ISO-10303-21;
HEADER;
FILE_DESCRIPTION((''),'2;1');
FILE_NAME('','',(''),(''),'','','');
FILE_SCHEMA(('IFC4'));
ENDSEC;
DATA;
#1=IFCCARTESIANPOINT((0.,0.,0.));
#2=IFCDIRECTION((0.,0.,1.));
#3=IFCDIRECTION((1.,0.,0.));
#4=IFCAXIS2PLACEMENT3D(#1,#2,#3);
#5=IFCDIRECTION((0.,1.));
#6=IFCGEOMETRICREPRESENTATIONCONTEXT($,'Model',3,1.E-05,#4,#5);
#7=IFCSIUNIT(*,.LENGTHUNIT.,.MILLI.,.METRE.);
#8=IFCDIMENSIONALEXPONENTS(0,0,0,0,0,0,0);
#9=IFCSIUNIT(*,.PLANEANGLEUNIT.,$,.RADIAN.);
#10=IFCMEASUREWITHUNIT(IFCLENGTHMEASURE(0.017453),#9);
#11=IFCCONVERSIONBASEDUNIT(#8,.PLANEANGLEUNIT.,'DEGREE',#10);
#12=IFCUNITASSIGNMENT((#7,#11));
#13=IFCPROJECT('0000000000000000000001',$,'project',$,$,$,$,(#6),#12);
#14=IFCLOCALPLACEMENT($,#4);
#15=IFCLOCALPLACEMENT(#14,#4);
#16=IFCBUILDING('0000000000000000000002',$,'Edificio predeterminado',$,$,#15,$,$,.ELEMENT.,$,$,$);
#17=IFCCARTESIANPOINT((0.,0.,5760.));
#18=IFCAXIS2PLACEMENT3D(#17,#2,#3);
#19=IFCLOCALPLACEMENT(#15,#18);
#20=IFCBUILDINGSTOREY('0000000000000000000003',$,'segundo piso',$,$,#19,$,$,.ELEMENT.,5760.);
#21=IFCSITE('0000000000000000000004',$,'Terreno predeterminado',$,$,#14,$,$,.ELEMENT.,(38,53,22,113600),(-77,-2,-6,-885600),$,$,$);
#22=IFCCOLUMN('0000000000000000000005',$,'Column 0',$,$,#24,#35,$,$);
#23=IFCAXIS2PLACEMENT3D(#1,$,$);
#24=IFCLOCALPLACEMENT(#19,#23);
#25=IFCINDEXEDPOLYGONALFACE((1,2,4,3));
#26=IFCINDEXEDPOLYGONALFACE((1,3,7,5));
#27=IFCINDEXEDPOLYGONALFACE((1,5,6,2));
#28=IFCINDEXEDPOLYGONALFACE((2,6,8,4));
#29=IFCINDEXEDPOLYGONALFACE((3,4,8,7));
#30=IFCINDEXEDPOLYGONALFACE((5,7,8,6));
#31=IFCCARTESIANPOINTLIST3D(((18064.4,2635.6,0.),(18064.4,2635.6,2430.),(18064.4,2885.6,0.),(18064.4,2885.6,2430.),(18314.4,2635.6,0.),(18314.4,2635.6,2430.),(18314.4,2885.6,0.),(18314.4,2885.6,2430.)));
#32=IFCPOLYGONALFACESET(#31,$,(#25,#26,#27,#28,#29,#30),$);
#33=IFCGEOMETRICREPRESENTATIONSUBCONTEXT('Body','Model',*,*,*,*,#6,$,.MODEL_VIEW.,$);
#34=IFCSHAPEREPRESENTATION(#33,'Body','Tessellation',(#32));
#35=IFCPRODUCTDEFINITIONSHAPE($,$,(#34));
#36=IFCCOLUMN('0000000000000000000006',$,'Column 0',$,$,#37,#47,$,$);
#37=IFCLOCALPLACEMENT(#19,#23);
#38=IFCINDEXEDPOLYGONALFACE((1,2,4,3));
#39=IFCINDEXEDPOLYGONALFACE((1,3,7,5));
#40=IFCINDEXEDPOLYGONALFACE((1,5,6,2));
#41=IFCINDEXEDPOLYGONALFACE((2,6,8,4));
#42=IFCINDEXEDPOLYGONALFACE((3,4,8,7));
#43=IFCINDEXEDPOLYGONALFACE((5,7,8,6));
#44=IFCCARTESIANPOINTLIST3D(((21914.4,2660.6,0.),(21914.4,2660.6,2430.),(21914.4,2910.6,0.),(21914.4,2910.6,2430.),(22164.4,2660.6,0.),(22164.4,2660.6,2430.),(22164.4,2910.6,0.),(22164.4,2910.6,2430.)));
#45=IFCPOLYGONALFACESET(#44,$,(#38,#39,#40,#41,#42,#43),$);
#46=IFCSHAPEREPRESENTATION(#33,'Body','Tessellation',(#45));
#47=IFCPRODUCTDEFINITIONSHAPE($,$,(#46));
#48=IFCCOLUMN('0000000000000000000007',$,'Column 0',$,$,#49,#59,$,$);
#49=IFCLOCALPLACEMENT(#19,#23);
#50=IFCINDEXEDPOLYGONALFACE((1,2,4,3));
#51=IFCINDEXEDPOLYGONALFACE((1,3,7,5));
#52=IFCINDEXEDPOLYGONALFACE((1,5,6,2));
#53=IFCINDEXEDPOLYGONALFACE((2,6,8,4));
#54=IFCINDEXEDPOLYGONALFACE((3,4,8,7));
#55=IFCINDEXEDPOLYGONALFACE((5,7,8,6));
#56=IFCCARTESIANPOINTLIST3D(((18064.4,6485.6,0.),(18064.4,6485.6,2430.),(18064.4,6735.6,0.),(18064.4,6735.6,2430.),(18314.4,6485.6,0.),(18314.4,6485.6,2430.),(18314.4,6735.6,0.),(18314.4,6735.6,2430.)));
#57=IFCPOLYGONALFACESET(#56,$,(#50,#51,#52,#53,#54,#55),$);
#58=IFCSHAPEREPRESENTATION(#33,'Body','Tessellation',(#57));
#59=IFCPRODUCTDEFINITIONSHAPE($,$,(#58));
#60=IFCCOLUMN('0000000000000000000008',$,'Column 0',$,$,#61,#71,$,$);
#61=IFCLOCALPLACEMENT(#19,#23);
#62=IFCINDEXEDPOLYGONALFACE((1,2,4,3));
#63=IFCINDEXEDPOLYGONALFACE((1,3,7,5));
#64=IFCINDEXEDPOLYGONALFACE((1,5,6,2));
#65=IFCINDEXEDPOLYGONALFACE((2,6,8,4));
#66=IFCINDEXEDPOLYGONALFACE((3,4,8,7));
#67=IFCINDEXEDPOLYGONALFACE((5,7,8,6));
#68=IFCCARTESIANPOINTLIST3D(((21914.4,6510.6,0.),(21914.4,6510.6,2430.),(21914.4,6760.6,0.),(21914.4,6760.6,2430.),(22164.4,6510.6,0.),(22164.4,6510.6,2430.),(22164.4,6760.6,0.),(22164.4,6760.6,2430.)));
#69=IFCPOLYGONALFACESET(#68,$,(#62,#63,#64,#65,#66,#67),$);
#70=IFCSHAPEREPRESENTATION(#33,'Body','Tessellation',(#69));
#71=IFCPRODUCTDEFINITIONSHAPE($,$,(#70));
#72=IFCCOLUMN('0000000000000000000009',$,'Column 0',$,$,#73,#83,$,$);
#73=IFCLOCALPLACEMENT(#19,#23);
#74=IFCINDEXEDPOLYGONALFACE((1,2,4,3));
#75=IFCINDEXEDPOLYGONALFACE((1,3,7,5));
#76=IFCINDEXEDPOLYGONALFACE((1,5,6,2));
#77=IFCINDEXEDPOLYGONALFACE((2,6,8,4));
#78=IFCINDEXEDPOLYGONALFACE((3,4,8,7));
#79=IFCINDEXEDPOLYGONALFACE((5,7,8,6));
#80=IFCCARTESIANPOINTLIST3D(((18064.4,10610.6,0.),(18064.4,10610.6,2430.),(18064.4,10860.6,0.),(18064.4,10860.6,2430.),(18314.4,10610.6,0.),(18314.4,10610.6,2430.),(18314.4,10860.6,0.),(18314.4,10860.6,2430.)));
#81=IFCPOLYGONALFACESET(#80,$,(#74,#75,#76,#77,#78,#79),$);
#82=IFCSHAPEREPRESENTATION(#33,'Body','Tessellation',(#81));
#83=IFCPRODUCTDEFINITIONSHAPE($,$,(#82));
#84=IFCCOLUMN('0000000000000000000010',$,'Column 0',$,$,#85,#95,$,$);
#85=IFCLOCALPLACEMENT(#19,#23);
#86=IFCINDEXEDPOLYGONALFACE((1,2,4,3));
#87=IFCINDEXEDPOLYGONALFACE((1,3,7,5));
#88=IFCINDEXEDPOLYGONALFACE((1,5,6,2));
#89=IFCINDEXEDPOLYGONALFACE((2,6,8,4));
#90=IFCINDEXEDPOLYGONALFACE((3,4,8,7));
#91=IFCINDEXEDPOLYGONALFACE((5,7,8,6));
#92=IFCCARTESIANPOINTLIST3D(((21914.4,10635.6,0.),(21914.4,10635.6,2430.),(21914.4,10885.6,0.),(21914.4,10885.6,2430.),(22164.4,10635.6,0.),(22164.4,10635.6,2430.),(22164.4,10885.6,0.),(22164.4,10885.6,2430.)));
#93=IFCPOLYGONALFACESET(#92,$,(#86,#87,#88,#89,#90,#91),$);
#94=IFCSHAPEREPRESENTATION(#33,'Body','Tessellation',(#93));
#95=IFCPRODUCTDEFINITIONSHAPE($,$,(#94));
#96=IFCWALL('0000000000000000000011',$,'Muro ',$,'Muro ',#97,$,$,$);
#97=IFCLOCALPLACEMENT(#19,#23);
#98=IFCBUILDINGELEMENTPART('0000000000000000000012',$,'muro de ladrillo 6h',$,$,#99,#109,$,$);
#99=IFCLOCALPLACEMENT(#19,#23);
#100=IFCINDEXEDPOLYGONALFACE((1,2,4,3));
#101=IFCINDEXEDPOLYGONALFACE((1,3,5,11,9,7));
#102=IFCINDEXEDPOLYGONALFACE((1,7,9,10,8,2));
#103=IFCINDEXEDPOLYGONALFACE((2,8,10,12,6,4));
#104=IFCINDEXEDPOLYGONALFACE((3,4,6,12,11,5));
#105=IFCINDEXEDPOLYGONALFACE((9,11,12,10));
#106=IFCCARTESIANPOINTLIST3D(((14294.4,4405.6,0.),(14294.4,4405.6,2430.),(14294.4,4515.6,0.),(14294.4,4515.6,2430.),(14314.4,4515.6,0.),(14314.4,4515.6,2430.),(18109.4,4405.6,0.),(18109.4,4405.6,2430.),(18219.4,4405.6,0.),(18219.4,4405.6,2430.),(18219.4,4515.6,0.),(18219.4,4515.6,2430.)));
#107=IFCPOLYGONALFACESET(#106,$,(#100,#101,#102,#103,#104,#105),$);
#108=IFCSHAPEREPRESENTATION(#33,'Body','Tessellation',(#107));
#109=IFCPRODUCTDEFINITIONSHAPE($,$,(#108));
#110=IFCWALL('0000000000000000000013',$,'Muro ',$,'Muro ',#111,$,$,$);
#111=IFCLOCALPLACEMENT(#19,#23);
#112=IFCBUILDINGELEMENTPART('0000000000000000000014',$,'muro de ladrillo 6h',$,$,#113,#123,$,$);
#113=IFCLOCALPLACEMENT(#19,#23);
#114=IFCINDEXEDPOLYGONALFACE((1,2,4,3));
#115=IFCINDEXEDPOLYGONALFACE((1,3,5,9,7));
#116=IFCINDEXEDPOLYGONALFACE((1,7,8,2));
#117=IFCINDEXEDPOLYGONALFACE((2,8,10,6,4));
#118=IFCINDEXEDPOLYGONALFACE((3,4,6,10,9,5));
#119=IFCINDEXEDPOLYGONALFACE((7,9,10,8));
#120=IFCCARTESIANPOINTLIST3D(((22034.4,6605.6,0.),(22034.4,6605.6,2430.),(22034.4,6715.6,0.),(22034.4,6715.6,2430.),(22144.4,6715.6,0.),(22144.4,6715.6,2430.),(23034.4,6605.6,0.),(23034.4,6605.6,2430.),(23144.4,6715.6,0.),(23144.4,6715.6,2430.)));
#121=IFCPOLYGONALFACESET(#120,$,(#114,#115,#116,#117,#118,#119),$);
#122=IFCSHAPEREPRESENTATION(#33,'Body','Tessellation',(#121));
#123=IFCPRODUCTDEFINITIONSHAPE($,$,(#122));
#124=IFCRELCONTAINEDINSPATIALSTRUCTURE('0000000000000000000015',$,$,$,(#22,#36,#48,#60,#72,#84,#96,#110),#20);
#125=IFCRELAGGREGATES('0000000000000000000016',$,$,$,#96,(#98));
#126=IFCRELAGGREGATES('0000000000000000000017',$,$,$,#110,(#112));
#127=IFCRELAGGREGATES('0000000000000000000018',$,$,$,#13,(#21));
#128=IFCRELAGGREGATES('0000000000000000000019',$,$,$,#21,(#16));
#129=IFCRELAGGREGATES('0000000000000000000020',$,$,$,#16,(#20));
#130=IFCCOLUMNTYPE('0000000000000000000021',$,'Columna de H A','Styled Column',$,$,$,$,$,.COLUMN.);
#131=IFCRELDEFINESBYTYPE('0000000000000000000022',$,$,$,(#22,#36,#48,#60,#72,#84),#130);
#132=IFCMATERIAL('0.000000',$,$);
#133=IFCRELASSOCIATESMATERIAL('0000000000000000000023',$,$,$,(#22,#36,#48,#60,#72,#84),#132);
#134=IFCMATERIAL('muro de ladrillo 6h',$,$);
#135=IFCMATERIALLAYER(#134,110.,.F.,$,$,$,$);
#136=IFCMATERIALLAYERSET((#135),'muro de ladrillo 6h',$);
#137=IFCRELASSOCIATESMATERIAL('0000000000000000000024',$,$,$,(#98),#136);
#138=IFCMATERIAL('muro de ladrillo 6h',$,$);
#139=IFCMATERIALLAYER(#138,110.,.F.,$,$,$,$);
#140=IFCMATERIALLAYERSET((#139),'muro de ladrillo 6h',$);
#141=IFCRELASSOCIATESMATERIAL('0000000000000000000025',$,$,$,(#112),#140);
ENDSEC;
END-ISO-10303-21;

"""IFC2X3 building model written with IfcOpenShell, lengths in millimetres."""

from ifc_helpers import new_model, entity, si_unit, converted_unit, direction, frame, origin_with_axes, place, context, subcontext, project, spatial, polyline, outline, extrude, material, layer, layer_set, layer_usage, type_object, element, aggregate, save


model = new_model("IFC2X3")

# Units and contexts
model_context = context("Model", 3, precision=1e-05, world=origin_with_axes(), true_north=direction((0.0, 1.0)))
body_context = subcontext(model_context, "Body", "Model", "MODEL_VIEW")
ifc_project = project(units=[si_unit("LENGTHUNIT", "METRE", prefix="MILLI"), converted_unit("PLANEANGLEUNIT", "DEGREE", entity("IfcLengthMeasure", 0.017453), si_unit("PLANEANGLEUNIT", "RADIAN"), dimensions=[0, 0, 0, 0, 0, 0, 0])], contexts=[model_context])

# Site, building, storey
site_placement = place(None, origin_with_axes())
site = spatial("IfcSite", under=ifc_project, at=site_placement, Name="Terreno predeterminado", CompositionType="ELEMENT", RefLatitude=(38, 53, 22, 113600), RefLongitude=(-77, -2, -6, -885600))
building_placement = place(site_placement, origin_with_axes())
building = spatial("IfcBuilding", under=site, at=building_placement, Name="Edificio predeterminado", CompositionType="ELEMENT")
storey_placement = place(building_placement, frame((0.0, 0.0, 5760.0), z_axis=(0.0, 0.0, 1.0), x_axis=(1.0, 0.0, 0.0)))
storey = spatial("IfcBuildingStorey", under=building, at=storey_placement, Name="segundo piso", CompositionType="ELEMENT", Elevation=5760.0)

# Columns
ifc_material_1 = material(Name="0.000000")
column_type = type_object("IfcColumnType", Name="Columna de H A", Description="Styled Column", PredefinedType="COLUMN")
for number, where, z_axis, x_axis, name in (
    (1, (18189.4, 2760.6, 0.0), (0.0, 0.0, 1.0), (1.0, 0.0, 0.0), "Column 0"),
    (2, (22039.4, 2785.6, 0.0), (0.0, 0.0, 1.0), (1.0, 0.0, 0.0), "Column 0"),
    (3, (18189.4, 6610.6, 0.0), (0.0, 0.0, 1.0), (1.0, 0.0, 0.0), "Column 0"),
    (4, (22039.4, 6635.6, 0.0), (0.0, 0.0, 1.0), (1.0, 0.0, 0.0), "Column 0"),
    (5, (18189.4, 10735.6, 0.0), (0.0, 0.0, 1.0), (1.0, 0.0, 0.0), "Column 0"),
    (6, (22039.4, 10760.6, 0.0), (0.0, 0.0, 1.0), (1.0, 0.0, 0.0), "Column 0"),
):
    element("IfcColumn", number, at=place(storey_placement, frame(where, z_axis=z_axis, x_axis=x_axis)), inside=storey, type_object=column_type, material=ifc_material_1, Name=name, context=body_context, shape_type="SweptSolid", body=[
        extrude(outline(polyline([(-125.0, -125.0), (125.0, -125.0), (125.0, 125.0), (-125.0, 125.0), (-125.0, -125.0)])), origin_with_axes(), (0.0, 0.0, 1.0), 2430.0),
    ])

# Walls, building element parts
wall_1_placement = place(storey_placement, frame((18164.4, 4460.6, 0.0), z_axis=(0.0, 0.0, 1.0), x_axis=(-1.0, 0.0, 0.0)))
wall_1 = element("IfcWall", 7, at=wall_1_placement, inside=storey, Name="Muro ", ObjectType="Muro ")
ifc_material_2 = material(Name="muro de ladrillo 6h")
ifc_layer_1 = layer(ifc_material_2, 110.0, ventilated=False)
ifc_layer_set_1 = layer_set([ifc_layer_1], Name="muro de ladrillo 6h")
ifc_layer_usage_1 = layer_usage(ifc_layer_set_1, "AXIS2", "NEGATIVE", -55.0)
building_element_part_1_placement = place(wall_1_placement, origin_with_axes())
building_element_part_1 = element("IfcBuildingElementPart", 8, at=building_element_part_1_placement, material=ifc_layer_usage_1, Name="muro de ladrillo 6h", context=body_context, shape_type="SweptSolid", body=[
    extrude(outline(polyline([(3870.0, 55.0), (3870.0, -55.0), (3850.0, -55.0), (-55.0, -55.0), (-55.0, 55.0), (55.0, 55.0), (3870.0, 55.0)])), origin_with_axes(), (0.0, 0.0, 1.0), 2430.0),
])
aggregate(wall_1, [building_element_part_1])
wall_2_placement = place(storey_placement, frame((22089.4, 6660.6, 0.0), z_axis=(0.0, 0.0, 1.0), x_axis=(1.0, 0.0, 0.0)))
wall_2 = element("IfcWall", 9, at=wall_2_placement, inside=storey, Name="Muro ", ObjectType="Muro ")
ifc_material_3 = material(Name="muro de ladrillo 6h")
ifc_layer_2 = layer(ifc_material_3, 110.0, ventilated=False)
ifc_layer_set_2 = layer_set([ifc_layer_2], Name="muro de ladrillo 6h")
ifc_layer_usage_2 = layer_usage(ifc_layer_set_2, "AXIS2", "NEGATIVE", -55.0)
building_element_part_2_placement = place(wall_2_placement, origin_with_axes())
building_element_part_2 = element("IfcBuildingElementPart", 10, at=building_element_part_2_placement, material=ifc_layer_usage_2, Name="muro de ladrillo 6h", context=body_context, shape_type="SweptSolid", body=[
    extrude(outline(polyline([(1055.0, 55.0), (945.0, -55.0), (-55.0, -55.0), (-55.0, 55.0), (55.0, 55.0), (1055.0, 55.0)])), origin_with_axes(), (0.0, 0.0, 1.0), 2430.0),
])
aggregate(wall_2, [building_element_part_2])

save(model, "model.ifc")
